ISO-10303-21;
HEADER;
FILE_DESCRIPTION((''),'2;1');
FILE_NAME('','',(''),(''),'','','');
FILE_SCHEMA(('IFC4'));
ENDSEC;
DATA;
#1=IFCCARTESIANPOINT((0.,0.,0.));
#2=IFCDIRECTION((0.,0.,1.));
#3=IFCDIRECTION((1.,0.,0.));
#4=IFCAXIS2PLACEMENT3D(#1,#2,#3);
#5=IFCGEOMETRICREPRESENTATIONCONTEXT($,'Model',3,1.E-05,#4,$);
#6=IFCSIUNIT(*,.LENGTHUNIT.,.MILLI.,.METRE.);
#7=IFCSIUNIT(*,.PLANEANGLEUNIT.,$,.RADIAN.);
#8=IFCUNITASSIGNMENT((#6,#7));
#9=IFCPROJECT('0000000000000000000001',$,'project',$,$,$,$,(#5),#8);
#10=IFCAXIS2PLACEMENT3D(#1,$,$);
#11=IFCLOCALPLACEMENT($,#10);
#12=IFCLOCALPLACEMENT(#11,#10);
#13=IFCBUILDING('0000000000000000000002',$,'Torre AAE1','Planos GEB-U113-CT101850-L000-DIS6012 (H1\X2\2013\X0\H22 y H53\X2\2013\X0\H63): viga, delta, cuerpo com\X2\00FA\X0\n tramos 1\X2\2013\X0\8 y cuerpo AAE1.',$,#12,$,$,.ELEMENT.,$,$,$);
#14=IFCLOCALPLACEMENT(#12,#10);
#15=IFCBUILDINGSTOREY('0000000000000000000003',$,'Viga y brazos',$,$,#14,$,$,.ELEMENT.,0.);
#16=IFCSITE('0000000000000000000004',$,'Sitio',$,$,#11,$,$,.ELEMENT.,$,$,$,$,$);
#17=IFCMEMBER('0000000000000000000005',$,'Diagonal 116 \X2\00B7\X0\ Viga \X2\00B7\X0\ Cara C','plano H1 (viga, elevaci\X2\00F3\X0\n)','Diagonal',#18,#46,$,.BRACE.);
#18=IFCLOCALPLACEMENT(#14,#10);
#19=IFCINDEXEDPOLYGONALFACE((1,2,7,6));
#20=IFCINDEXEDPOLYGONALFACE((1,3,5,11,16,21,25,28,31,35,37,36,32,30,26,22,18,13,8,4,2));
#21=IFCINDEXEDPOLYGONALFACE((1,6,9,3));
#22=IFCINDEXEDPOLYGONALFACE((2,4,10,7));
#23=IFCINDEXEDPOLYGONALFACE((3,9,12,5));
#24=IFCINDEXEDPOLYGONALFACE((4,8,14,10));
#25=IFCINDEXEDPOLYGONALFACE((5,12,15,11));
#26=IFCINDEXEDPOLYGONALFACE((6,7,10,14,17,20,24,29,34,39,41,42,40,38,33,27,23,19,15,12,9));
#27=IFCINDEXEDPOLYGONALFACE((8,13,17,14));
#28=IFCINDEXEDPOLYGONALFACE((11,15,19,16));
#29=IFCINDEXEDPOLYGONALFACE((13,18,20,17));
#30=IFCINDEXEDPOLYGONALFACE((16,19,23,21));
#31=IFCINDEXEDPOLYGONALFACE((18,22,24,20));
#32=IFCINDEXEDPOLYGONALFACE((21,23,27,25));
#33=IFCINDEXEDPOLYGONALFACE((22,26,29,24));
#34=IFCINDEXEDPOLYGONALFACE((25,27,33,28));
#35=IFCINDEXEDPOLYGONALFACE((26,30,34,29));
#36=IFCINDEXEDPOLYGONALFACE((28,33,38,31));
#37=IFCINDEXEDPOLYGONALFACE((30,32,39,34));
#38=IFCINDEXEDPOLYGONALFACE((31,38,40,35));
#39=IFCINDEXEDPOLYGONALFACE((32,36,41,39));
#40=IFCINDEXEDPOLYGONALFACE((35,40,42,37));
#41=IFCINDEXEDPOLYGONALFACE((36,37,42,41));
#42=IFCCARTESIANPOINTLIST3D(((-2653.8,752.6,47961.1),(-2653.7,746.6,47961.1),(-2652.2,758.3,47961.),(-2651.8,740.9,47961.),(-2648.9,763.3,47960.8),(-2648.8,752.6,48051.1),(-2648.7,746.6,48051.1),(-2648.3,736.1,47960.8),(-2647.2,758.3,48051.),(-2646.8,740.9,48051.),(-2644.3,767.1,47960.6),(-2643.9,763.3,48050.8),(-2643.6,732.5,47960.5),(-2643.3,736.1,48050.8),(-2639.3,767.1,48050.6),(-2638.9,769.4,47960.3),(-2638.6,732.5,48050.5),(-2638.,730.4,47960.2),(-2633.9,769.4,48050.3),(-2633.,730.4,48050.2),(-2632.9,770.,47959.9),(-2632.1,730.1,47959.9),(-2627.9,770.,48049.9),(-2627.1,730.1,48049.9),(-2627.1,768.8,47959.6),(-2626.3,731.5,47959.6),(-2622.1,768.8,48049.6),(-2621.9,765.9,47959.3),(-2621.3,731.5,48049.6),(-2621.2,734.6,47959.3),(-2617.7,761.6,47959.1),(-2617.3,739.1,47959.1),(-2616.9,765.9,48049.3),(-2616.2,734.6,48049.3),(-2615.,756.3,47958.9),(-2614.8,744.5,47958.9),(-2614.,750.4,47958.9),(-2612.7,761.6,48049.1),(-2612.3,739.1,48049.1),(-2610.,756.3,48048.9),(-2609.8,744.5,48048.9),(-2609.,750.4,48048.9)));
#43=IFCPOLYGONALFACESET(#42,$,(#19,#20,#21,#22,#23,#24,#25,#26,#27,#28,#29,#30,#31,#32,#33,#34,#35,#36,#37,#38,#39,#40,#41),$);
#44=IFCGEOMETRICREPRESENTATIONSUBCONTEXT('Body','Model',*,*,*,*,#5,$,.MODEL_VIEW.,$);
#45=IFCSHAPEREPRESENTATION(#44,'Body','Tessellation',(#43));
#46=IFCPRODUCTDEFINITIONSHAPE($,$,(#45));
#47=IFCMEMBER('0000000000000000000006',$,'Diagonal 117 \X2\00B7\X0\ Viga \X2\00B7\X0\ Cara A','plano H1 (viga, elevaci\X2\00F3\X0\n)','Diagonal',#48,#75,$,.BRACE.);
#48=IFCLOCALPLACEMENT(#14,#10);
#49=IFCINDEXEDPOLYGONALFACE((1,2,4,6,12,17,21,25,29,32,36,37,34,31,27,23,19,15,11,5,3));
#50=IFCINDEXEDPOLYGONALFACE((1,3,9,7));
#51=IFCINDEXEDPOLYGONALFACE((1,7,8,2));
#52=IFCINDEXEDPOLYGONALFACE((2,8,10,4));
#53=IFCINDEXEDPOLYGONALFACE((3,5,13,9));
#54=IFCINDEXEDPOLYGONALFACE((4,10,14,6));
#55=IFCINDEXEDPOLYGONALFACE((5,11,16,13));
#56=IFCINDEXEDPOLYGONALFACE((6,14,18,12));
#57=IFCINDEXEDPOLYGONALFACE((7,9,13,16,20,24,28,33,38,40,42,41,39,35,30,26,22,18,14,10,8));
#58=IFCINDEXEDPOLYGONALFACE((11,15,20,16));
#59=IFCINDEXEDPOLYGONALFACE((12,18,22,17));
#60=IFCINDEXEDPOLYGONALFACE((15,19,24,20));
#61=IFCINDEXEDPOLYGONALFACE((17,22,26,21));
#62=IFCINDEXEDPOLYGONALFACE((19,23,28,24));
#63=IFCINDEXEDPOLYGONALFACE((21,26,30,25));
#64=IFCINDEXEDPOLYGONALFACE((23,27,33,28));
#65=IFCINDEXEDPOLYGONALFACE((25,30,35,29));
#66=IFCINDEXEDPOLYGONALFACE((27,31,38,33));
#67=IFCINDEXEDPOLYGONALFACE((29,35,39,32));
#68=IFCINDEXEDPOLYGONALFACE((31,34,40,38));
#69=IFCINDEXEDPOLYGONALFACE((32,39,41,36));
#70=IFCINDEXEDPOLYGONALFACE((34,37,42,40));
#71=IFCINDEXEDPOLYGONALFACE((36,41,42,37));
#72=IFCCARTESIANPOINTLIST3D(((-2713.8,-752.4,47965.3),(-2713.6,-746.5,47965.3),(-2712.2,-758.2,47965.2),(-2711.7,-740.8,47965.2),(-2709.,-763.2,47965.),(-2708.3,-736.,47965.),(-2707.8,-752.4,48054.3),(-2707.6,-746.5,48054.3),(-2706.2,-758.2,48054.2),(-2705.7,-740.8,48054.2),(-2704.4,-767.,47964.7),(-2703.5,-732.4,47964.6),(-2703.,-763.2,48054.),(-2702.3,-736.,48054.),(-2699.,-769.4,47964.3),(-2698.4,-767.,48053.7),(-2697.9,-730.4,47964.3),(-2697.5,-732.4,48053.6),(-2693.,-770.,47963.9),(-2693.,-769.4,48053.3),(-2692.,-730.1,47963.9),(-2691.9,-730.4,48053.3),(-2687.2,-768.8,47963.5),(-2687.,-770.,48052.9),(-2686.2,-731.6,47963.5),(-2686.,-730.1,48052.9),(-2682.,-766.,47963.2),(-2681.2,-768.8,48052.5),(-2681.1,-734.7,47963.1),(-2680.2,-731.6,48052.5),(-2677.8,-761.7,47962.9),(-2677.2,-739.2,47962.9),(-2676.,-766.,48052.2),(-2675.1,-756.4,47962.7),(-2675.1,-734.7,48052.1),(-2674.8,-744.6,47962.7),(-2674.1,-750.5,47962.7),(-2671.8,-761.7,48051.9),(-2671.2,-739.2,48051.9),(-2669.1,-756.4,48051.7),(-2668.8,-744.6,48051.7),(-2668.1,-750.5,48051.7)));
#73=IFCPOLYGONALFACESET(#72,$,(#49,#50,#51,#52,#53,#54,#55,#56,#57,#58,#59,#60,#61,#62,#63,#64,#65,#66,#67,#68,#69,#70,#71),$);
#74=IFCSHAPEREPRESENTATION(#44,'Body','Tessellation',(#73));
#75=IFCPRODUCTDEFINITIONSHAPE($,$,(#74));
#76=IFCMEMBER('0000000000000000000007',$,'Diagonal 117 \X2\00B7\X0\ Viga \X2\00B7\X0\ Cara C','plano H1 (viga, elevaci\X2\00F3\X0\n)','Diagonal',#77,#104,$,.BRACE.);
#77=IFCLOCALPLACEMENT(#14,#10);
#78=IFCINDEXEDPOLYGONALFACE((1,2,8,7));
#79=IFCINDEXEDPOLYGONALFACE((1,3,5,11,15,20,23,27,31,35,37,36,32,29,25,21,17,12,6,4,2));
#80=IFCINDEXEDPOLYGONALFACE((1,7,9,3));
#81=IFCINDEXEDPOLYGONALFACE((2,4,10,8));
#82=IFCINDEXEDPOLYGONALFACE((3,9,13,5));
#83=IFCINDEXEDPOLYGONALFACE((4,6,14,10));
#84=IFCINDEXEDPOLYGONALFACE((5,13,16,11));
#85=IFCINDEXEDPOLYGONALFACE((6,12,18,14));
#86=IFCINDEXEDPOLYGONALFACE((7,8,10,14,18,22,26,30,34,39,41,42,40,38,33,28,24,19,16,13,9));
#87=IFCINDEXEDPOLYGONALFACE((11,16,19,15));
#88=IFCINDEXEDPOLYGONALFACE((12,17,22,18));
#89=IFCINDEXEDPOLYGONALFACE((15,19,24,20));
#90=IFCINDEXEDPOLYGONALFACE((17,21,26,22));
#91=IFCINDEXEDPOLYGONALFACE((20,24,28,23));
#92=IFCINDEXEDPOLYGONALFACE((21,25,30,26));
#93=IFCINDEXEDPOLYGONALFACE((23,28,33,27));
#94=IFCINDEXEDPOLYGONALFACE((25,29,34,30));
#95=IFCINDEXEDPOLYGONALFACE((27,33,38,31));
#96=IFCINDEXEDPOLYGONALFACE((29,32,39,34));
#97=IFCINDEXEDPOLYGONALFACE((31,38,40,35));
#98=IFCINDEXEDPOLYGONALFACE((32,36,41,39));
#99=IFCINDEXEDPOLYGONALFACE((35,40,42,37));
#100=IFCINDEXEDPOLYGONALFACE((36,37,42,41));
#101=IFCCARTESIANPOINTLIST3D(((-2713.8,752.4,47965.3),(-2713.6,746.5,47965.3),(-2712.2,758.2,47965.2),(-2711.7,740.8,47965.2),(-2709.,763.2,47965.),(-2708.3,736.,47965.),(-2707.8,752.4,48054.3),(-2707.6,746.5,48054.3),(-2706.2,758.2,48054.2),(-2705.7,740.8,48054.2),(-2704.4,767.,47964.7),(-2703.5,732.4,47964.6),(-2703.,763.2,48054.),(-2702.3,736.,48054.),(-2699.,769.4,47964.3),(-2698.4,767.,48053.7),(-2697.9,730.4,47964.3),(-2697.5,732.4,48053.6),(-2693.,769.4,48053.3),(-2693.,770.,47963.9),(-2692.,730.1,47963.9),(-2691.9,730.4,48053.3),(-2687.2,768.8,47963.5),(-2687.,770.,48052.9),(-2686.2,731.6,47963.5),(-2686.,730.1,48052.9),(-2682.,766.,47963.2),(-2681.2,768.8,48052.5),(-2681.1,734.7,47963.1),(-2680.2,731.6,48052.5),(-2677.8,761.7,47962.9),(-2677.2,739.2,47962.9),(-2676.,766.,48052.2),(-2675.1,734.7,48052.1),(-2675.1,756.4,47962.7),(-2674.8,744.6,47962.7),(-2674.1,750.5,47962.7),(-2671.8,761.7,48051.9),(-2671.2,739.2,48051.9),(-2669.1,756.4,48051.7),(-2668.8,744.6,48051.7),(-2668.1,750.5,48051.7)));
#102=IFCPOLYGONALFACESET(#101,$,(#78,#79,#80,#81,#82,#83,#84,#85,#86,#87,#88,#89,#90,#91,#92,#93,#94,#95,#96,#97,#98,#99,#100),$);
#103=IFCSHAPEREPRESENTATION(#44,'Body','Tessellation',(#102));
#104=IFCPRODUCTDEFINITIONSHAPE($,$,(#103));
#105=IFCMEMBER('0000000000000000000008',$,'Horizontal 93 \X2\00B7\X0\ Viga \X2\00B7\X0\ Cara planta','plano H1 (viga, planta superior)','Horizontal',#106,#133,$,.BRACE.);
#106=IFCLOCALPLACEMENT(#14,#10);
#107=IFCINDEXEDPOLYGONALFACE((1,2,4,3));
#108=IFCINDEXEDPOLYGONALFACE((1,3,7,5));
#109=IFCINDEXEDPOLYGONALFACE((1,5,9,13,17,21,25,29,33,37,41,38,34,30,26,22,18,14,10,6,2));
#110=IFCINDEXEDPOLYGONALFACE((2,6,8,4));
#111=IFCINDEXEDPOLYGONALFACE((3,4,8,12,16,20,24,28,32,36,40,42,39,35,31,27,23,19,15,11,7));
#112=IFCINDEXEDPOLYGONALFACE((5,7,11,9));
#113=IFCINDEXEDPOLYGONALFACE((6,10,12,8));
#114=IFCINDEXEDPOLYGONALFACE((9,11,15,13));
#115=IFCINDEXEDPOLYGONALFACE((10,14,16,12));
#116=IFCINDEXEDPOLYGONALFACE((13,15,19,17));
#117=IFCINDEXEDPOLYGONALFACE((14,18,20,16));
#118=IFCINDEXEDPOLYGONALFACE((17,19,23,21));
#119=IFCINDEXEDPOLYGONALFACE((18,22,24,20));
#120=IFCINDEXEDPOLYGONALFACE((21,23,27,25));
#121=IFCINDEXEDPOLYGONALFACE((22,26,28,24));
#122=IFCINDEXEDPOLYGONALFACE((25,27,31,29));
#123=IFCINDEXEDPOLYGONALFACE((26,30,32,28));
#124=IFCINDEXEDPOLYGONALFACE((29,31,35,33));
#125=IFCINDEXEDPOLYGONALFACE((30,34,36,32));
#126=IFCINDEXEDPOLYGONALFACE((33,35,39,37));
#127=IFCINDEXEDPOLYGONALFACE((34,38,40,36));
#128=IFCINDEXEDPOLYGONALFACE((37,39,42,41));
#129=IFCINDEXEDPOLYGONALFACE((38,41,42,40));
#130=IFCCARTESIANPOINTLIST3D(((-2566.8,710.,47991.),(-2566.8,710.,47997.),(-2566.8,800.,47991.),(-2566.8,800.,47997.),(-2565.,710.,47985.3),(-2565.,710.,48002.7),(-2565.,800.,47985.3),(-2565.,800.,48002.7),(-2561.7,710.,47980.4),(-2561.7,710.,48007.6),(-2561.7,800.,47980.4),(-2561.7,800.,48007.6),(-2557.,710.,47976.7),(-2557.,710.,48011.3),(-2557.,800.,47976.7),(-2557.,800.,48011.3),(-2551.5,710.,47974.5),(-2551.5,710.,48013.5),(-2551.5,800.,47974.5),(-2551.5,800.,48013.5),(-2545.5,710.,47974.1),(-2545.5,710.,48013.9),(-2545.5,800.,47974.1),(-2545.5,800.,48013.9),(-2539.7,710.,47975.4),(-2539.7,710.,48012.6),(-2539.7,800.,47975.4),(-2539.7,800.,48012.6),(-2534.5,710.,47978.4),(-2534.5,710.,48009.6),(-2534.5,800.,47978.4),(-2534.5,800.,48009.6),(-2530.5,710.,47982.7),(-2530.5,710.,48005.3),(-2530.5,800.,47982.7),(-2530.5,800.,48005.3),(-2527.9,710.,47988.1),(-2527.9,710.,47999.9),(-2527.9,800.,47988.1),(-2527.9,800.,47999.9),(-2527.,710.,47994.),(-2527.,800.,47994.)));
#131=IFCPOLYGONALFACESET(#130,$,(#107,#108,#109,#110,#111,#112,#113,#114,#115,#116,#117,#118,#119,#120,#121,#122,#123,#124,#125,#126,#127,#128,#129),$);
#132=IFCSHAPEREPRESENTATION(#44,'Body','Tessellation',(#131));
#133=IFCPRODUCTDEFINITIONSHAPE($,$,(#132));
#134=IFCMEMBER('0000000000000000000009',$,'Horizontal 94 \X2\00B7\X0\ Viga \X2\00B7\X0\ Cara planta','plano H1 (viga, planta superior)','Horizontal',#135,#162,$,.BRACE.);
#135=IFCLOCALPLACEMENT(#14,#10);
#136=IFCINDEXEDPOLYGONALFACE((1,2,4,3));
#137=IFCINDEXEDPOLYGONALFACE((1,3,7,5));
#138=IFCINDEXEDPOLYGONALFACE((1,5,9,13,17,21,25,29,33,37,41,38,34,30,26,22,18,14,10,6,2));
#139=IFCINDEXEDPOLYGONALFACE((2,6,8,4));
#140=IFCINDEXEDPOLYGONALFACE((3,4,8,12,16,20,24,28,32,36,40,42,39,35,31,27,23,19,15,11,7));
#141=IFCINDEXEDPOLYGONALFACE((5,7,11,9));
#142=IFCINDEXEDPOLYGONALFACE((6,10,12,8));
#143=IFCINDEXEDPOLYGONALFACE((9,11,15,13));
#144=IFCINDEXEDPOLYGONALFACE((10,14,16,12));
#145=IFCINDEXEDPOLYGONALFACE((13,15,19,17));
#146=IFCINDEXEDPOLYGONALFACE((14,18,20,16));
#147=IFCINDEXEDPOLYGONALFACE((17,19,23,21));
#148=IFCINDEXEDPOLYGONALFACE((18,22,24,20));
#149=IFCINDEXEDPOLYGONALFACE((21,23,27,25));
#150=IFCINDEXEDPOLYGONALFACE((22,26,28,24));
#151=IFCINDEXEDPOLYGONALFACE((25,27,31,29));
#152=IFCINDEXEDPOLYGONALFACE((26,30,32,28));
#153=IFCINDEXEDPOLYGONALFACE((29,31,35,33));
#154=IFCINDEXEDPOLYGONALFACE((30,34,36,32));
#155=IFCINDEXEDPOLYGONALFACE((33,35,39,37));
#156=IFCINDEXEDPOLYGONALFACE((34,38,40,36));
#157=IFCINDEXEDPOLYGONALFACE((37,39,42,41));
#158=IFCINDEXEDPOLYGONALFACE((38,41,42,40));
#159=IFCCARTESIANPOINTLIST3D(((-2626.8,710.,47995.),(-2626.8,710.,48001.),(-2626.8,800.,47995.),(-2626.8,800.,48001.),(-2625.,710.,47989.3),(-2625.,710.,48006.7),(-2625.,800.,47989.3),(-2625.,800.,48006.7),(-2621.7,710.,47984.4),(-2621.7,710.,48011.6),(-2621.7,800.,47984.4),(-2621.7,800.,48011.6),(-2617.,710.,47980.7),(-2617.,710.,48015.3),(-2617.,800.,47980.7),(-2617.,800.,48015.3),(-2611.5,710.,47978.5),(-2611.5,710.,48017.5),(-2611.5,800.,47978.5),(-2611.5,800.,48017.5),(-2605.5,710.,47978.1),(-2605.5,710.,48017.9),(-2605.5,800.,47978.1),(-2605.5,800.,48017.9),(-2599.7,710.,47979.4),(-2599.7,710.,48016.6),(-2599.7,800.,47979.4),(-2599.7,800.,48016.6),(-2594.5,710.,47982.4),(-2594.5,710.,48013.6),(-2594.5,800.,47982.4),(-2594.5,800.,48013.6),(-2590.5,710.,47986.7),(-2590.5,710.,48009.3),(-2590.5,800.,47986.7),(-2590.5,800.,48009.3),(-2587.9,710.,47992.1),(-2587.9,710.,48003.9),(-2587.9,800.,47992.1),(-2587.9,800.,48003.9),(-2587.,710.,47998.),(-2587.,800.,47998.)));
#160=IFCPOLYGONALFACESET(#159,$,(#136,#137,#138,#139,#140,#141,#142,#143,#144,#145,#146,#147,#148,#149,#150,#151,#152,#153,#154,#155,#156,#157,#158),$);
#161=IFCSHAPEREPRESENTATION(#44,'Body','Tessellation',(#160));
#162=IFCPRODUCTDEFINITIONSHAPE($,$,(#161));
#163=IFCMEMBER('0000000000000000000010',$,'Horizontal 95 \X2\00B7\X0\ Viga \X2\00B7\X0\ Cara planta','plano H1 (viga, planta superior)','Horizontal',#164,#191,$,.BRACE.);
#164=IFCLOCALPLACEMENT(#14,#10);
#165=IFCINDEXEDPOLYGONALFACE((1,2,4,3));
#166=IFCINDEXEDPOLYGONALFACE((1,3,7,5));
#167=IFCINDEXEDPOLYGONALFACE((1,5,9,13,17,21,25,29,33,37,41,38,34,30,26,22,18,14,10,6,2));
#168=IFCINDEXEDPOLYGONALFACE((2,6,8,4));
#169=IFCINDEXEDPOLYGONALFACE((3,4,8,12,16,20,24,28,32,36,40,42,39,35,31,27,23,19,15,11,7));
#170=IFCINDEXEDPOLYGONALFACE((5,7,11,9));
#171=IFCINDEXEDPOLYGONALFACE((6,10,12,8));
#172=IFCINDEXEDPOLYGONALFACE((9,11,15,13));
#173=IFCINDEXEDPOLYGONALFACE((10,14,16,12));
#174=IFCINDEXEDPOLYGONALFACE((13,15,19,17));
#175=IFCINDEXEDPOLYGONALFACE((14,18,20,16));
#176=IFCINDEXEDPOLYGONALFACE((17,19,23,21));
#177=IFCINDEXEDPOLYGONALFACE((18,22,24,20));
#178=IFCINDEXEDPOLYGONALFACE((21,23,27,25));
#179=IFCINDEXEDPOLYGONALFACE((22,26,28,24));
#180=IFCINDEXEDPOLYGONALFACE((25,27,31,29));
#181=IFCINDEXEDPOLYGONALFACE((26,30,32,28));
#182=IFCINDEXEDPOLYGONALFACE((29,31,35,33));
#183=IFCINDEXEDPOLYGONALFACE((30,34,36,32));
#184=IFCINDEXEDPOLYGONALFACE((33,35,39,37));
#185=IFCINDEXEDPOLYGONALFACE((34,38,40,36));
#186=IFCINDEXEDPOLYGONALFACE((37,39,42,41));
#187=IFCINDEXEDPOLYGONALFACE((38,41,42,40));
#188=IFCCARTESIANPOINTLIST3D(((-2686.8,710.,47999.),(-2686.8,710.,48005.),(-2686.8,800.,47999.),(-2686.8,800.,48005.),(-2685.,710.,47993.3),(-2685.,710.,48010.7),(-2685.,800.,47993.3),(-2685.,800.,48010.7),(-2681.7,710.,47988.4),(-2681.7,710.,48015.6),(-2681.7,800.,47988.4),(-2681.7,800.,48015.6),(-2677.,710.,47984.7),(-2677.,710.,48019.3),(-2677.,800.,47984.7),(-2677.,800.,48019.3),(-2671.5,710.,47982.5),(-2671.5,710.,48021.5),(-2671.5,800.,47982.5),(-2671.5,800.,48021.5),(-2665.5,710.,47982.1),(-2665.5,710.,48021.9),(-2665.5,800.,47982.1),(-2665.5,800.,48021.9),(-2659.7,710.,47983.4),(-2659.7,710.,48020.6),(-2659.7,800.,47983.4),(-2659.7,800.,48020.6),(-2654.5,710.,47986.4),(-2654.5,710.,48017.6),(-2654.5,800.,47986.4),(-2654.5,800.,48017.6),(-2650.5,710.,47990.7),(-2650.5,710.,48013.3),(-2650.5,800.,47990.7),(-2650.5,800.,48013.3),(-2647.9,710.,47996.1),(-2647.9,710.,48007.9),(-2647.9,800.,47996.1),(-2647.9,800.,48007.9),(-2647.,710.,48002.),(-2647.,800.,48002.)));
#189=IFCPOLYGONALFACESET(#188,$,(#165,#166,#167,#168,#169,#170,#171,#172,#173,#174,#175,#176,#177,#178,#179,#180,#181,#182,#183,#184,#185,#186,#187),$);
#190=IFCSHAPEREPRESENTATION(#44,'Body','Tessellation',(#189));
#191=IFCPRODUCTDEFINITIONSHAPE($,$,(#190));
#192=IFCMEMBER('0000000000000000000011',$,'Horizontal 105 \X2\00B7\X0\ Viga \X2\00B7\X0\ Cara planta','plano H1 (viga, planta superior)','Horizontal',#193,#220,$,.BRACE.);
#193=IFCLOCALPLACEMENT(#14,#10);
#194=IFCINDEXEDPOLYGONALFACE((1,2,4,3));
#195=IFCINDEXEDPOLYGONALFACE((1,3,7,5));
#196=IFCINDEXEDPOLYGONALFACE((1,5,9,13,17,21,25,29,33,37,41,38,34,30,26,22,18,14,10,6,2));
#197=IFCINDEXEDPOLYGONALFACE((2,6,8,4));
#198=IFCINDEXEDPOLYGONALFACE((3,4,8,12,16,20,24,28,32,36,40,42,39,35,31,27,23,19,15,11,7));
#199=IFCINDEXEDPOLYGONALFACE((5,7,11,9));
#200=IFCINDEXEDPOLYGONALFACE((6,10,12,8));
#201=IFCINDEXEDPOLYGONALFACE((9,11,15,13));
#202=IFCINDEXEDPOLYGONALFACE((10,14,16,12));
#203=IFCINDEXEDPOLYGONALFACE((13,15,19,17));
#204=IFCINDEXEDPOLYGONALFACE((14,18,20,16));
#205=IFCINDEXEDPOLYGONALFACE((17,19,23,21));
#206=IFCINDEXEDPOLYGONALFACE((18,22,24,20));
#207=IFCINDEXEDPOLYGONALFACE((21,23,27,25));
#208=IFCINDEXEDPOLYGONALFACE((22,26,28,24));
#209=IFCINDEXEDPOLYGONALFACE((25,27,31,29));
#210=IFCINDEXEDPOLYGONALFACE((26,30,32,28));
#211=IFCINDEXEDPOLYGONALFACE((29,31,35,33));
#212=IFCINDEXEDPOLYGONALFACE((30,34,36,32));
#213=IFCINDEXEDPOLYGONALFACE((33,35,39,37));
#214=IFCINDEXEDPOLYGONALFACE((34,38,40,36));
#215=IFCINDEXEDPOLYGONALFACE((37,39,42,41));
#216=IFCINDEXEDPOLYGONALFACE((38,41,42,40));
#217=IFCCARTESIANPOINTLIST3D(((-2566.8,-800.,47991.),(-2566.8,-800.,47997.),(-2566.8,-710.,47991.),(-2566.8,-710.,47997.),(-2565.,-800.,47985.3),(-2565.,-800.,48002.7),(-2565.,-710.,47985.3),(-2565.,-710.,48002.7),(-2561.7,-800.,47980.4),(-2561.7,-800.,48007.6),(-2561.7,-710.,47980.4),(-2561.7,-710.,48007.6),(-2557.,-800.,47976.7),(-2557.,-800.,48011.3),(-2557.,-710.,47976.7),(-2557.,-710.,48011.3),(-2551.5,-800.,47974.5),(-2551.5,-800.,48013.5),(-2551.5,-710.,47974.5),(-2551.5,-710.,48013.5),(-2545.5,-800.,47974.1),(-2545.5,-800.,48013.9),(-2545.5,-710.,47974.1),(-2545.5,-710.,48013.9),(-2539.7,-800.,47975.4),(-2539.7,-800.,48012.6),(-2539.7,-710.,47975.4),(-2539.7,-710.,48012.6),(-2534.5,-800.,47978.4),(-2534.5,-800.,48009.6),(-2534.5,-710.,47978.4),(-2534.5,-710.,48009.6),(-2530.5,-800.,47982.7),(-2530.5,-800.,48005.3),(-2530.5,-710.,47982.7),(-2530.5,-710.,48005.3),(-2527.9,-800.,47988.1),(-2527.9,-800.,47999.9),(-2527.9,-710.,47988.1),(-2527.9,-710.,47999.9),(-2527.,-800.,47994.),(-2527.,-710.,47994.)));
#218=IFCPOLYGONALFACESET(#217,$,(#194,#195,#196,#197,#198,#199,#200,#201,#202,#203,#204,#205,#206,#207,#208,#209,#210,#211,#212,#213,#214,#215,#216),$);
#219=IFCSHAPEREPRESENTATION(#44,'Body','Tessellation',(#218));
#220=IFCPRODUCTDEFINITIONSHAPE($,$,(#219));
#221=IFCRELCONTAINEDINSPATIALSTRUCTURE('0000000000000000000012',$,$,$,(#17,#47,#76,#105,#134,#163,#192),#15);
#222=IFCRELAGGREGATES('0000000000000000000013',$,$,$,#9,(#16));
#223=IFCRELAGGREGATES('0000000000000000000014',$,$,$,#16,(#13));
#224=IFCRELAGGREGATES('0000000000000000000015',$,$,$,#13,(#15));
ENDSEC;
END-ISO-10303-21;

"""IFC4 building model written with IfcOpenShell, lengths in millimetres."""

from ifc_helpers import new_model, si_unit, frame, origin, origin_with_axes, place, context, subcontext, project, spatial, circle, extrude, element, save


model = new_model("IFC4")

# Units and contexts
model_context = context("Model", 3, precision=1e-05, world=origin_with_axes())
body_context = subcontext(model_context, "Body", "Model", "MODEL_VIEW")
ifc_project = project(units=[si_unit("LENGTHUNIT", "METRE", prefix="MILLI"), si_unit("PLANEANGLEUNIT", "RADIAN")], contexts=[model_context])

# Site, building, storey
site_placement = place(None, origin())
site = spatial("IfcSite", under=ifc_project, at=site_placement, Name="Sitio", CompositionType="ELEMENT")
building_placement = place(site_placement, origin())
building = spatial("IfcBuilding", under=site, at=building_placement, Name="Torre AAE1", Description="Planos GEB-U113-CT101850-L000-DIS6012 (H1–H22 y H53–H63): viga, delta, cuerpo común tramos 1–8 y cuerpo AAE1.", CompositionType="ELEMENT")
storey_placement = place(building_placement, origin())
storey = spatial("IfcBuildingStorey", under=building, at=storey_placement, Name="Viga y brazos", CompositionType="ELEMENT", Elevation=0.0)

# Members
for number, where, z_axis, x_axis, name in (
    (1, (-2634.0, 750.0, 47960.0), (0.05547, 0.0, 0.99846), (0.960111, -0.274484, -0.05334), "Diagonal 116 · Viga · Cara C"),
):
    element("IfcMember", number, at=place(storey_placement, frame(where, z_axis=z_axis, x_axis=x_axis)), inside=storey, Name=name, Description="plano H1 (viga, elevación)", ObjectType="Diagonal", PredefinedType="BRACE", context=body_context, shape_type="SweptSolid", body=[
        extrude(circle(Radius=20.0), None, (0.0, 0.0, 1.0), 90.1),
    ])
for number, where, z_axis, x_axis, name in (
    (2, (-2694.0, -750.0, 47964.0), (0.067263, 0.0, 0.997735), (0.960948, 0.26904, -0.064783), "Diagonal 117 · Viga · Cara A"),
    (3, (-2694.0, 750.0, 47964.0), (0.067263, 0.0, 0.997735), (0.960948, -0.26904, -0.064783), "Diagonal 117 · Viga · Cara C"),
):
    element("IfcMember", number, at=place(storey_placement, frame(where, z_axis=z_axis, x_axis=x_axis)), inside=storey, Name=name, Description="plano H1 (viga, elevación)", ObjectType="Diagonal", PredefinedType="BRACE", context=body_context, shape_type="SweptSolid", body=[
        extrude(circle(Radius=20.0), None, (0.0, 0.0, 1.0), 89.2),
    ])
for number, where, z_axis, x_axis, name in (
    (4, (-2547.0, 710.0, 47994.0), (0.0, 1.0, 0.0), (1.0, 0.0, 0.0), "Horizontal 93 · Viga · Cara planta"),
    (5, (-2607.0, 710.0, 47998.0), (0.0, 1.0, 0.0), (1.0, 0.0, 0.0), "Horizontal 94 · Viga · Cara planta"),
    (6, (-2667.0, 710.0, 48002.0), (0.0, 1.0, 0.0), (1.0, 0.0, 0.0), "Horizontal 95 · Viga · Cara planta"),
    (7, (-2547.0, -710.0, 47994.0), (0.0, -1.0, 0.0), (1.0, 0.0, 0.0), "Horizontal 105 · Viga · Cara planta"),
):
    element("IfcMember", number, at=place(storey_placement, frame(where, z_axis=z_axis, x_axis=x_axis)), inside=storey, Name=name, Description="plano H1 (viga, planta superior)", ObjectType="Horizontal", PredefinedType="BRACE", context=body_context, shape_type="SweptSolid", body=[
        extrude(circle(Radius=20.0), None, (0.0, 0.0, 1.0), 90.0),
    ])

save(model, "model.ifc")
